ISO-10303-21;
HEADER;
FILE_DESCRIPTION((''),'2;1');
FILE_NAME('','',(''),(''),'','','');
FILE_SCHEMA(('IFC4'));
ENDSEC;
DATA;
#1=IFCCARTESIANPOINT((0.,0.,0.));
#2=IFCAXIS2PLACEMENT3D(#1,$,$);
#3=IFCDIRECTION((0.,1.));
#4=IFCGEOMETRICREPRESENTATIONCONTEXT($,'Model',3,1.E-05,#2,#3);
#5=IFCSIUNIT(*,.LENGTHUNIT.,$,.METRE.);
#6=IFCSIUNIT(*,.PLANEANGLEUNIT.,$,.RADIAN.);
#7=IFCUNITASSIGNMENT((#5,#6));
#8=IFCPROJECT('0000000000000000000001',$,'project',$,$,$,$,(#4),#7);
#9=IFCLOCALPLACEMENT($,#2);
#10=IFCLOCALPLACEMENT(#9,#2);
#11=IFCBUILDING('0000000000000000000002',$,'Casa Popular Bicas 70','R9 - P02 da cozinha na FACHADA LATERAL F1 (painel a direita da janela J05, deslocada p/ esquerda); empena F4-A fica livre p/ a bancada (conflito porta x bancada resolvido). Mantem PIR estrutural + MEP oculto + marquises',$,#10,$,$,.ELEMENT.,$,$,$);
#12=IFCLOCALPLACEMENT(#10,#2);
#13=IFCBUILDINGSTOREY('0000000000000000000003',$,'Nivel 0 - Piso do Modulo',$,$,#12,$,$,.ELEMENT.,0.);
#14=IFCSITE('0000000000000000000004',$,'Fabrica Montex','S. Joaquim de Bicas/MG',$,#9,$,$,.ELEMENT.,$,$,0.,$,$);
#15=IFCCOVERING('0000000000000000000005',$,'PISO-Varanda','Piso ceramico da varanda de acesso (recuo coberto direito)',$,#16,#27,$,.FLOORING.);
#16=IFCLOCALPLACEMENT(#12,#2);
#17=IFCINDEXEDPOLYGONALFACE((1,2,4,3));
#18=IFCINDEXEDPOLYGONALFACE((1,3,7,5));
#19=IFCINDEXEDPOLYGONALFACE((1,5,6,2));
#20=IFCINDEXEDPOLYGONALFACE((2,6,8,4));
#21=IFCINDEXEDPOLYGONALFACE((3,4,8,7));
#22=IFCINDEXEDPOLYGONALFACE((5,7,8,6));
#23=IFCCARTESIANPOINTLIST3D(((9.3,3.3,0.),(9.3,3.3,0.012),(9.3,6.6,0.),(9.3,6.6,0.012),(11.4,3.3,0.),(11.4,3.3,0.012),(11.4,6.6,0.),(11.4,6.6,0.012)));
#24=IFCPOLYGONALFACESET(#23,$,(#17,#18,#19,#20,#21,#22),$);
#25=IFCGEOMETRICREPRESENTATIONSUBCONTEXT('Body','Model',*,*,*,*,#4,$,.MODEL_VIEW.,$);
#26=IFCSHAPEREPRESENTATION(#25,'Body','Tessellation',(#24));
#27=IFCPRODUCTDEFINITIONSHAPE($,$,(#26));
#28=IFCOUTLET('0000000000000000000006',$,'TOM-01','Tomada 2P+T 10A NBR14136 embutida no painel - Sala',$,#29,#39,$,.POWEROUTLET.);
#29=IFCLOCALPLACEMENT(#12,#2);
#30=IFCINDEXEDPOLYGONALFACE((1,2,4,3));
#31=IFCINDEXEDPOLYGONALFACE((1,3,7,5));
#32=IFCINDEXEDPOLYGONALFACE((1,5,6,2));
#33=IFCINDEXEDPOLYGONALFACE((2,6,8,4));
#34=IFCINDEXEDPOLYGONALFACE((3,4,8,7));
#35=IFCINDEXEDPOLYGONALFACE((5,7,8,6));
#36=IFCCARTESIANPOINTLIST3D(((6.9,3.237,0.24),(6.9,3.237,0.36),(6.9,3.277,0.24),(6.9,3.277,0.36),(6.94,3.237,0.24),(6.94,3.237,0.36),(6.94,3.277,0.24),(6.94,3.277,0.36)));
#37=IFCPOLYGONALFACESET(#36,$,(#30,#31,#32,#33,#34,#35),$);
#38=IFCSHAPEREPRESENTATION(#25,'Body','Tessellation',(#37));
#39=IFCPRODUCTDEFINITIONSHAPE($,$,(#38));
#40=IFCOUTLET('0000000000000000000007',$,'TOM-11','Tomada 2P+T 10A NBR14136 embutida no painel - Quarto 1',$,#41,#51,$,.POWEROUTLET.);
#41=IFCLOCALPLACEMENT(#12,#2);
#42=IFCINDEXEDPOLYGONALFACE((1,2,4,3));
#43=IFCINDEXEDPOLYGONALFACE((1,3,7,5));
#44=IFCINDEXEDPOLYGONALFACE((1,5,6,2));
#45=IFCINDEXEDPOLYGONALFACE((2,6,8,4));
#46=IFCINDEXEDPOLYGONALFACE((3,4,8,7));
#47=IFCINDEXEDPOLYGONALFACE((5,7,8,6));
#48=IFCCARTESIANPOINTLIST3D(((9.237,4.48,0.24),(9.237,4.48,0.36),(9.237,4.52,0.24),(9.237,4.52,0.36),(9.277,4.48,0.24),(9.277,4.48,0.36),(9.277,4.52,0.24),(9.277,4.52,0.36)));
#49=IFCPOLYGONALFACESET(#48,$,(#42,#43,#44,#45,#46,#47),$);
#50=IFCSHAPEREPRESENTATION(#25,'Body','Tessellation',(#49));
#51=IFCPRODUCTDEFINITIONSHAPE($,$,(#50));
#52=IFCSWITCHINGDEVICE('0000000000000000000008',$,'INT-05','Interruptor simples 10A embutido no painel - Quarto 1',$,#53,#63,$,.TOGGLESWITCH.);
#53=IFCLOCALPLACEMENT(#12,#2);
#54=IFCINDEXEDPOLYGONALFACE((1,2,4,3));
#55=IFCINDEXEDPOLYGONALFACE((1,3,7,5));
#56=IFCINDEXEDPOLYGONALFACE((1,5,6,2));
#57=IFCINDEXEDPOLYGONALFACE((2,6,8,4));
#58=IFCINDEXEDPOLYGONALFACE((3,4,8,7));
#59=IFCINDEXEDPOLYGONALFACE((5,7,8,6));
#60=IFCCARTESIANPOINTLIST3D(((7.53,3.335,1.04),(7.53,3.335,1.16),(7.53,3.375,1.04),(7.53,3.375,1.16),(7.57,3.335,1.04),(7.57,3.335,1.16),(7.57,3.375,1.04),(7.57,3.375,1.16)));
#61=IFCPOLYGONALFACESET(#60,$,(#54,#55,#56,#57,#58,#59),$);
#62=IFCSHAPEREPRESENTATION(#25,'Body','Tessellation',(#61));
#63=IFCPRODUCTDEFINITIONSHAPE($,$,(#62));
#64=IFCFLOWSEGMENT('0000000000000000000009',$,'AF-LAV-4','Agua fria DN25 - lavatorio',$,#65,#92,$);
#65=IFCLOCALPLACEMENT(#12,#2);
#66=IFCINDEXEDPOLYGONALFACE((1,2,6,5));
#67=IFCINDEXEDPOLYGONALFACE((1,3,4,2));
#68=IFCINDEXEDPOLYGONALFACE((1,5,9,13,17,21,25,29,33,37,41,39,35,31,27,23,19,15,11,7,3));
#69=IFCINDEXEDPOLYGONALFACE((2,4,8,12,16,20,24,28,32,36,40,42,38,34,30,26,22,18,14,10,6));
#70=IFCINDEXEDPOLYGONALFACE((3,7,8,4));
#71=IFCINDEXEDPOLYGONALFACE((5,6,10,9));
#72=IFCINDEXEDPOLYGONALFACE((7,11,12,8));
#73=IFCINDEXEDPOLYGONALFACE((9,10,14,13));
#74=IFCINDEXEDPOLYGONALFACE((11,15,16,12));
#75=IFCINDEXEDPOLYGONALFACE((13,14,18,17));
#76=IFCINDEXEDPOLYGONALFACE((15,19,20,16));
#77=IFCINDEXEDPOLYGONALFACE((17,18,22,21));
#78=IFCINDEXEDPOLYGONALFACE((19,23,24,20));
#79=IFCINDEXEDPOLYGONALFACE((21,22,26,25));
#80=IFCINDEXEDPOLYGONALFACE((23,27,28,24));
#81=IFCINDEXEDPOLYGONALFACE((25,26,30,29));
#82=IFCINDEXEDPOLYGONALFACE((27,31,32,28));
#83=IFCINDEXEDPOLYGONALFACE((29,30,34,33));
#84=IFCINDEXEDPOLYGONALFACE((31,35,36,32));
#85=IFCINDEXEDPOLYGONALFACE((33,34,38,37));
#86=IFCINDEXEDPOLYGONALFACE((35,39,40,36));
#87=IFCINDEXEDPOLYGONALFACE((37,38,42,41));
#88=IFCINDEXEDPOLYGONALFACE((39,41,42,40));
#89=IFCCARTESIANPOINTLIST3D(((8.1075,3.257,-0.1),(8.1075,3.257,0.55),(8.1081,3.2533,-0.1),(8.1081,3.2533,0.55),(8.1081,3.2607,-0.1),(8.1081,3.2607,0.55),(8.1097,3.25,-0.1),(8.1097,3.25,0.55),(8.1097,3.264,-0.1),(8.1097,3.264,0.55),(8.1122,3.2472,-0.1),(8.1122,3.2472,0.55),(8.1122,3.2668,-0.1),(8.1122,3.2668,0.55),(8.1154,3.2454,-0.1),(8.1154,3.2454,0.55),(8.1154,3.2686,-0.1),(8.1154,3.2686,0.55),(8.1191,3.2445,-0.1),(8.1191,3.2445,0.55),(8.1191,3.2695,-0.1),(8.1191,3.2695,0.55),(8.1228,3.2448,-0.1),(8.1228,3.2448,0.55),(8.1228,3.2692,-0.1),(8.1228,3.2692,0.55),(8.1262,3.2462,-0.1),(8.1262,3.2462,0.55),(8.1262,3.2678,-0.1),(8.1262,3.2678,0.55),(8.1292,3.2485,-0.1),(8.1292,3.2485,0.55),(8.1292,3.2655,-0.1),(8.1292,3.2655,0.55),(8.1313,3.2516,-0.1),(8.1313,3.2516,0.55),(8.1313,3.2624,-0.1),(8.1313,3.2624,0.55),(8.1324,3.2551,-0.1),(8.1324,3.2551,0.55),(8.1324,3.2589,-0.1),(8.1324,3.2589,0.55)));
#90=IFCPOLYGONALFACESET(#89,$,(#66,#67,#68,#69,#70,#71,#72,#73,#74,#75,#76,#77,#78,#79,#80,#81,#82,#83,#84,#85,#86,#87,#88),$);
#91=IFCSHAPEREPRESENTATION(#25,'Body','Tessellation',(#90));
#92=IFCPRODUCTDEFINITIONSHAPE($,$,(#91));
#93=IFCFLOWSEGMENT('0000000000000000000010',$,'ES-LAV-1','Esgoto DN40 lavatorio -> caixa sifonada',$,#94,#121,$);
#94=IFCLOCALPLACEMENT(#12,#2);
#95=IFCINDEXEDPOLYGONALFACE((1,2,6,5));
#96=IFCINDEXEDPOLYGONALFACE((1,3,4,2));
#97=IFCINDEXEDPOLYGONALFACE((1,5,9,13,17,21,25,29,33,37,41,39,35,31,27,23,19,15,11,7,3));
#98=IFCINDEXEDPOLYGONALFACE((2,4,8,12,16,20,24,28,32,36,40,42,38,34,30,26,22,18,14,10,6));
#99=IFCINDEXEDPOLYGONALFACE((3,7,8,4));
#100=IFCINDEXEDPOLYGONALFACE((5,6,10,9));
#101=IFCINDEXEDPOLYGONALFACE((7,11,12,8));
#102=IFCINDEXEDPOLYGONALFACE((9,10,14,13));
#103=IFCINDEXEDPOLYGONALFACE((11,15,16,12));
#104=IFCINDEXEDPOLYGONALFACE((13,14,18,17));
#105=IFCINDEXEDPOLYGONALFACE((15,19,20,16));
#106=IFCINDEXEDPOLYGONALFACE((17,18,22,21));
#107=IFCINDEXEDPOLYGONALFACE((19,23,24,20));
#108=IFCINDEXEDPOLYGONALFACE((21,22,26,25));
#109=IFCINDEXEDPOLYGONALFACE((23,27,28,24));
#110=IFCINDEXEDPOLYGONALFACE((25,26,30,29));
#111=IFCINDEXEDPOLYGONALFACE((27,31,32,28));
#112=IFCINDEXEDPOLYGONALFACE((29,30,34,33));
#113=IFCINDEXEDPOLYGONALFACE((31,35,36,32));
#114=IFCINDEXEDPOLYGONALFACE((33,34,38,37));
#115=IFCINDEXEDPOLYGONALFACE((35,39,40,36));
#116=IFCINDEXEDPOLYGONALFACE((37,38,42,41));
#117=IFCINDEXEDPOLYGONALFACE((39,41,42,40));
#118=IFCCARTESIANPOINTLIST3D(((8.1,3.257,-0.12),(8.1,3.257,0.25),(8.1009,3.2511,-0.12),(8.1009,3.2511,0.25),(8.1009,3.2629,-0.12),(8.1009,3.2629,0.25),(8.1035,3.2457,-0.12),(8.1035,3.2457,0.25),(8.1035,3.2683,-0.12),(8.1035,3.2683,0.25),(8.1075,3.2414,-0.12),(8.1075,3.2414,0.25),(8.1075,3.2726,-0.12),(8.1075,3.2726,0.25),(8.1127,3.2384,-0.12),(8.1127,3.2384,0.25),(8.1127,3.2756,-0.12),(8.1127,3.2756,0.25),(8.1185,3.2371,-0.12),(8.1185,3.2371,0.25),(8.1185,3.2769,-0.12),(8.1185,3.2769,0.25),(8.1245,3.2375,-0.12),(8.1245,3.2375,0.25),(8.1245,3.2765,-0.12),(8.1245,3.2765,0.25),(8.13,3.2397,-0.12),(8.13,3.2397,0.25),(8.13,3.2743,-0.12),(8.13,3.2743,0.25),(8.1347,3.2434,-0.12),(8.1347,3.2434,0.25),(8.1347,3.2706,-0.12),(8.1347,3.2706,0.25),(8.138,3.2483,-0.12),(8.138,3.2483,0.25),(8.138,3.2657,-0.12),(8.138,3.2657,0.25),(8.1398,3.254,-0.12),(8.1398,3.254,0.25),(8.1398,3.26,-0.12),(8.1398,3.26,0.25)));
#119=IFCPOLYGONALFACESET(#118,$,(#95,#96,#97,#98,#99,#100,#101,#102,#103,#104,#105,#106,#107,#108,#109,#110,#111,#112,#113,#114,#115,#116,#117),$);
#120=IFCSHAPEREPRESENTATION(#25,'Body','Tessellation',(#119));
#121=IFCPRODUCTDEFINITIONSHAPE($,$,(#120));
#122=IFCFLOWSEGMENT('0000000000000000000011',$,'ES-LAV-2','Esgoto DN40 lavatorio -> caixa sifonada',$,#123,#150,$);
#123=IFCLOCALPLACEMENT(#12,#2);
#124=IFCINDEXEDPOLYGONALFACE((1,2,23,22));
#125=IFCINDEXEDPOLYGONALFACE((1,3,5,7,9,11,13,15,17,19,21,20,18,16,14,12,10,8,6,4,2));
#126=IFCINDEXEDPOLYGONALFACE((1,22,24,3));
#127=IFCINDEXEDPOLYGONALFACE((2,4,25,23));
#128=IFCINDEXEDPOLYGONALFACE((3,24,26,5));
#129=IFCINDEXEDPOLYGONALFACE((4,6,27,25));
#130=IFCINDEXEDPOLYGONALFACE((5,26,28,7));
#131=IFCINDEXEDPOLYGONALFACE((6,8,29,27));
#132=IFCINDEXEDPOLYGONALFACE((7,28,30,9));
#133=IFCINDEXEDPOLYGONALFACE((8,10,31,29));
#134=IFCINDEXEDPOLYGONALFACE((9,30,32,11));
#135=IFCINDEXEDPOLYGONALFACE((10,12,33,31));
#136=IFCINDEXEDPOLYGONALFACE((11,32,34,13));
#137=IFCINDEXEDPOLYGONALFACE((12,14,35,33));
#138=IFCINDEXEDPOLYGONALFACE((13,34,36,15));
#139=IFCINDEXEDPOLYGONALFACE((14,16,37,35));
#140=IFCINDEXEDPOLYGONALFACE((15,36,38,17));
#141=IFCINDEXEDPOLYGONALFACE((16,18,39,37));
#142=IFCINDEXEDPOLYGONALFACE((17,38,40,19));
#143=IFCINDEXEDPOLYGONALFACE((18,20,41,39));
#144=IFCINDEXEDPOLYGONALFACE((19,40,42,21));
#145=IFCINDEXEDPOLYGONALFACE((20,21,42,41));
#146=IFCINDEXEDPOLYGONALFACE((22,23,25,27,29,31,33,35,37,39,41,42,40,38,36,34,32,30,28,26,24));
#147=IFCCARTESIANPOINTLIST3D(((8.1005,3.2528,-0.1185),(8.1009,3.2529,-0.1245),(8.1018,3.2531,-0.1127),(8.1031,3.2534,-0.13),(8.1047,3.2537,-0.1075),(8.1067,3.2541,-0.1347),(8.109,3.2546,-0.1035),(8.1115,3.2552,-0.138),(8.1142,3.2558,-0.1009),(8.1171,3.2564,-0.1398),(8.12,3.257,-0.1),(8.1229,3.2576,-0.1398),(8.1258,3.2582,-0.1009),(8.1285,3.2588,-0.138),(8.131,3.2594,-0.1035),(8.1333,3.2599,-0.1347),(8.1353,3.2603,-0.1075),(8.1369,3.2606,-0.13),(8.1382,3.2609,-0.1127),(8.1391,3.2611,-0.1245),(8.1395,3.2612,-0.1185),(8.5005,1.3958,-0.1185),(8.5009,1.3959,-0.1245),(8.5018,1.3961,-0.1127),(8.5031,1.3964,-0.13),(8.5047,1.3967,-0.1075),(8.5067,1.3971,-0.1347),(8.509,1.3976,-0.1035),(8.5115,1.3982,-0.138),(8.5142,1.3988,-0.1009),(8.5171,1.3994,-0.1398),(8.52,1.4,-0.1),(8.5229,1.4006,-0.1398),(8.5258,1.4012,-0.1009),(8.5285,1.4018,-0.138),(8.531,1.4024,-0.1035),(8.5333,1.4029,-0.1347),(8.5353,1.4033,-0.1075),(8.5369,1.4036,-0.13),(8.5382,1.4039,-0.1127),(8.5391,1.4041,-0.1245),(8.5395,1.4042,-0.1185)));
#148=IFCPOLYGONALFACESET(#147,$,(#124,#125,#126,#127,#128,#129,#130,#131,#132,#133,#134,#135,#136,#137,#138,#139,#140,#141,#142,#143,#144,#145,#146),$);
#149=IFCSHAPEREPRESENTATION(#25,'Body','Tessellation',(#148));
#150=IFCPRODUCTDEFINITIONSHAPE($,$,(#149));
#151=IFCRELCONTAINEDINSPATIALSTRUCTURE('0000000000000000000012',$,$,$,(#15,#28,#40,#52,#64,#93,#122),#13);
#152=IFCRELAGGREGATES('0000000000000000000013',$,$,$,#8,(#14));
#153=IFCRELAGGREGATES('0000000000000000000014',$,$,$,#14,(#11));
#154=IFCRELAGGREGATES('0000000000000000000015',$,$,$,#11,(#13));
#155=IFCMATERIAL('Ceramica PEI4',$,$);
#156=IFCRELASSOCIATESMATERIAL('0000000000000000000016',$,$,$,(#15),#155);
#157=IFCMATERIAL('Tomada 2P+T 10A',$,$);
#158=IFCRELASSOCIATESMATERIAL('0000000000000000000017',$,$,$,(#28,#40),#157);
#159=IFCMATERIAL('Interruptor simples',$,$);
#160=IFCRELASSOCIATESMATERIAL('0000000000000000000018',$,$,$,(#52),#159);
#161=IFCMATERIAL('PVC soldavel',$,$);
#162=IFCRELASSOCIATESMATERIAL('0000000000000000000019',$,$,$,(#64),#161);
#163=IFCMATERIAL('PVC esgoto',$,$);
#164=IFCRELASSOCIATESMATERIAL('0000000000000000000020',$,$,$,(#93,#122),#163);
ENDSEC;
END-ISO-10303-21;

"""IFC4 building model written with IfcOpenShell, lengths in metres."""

from ifc_helpers import new_model, si_unit, direction, frame, frame_2d, origin, origin_2d, place, context, subcontext, project, spatial, rectangle, circle, extrude, material, element, save


model = new_model("IFC4")

# Units and contexts
model_context = context("Model", 3, precision=1e-05, world=origin(), true_north=direction((0.0, 1.0)))
body_context = subcontext(model_context, "Body", "Model", "MODEL_VIEW")
ifc_project = project(units=[si_unit("LENGTHUNIT", "METRE"), si_unit("PLANEANGLEUNIT", "RADIAN")], contexts=[model_context])

# Site, building, storey
site_placement = place(None, origin())
site = spatial("IfcSite", under=ifc_project, at=site_placement, Name="Fabrica Montex", Description="S. Joaquim de Bicas/MG", CompositionType="ELEMENT", RefElevation=0.0)
building_placement = place(site_placement, origin())
building = spatial("IfcBuilding", under=site, at=building_placement, Name="Casa Popular Bicas 70", Description="R9 - P02 da cozinha na FACHADA LATERAL F1 (painel a direita da janela J05, deslocada p/ esquerda); empena F4-A fica livre p/ a bancada (conflito porta x bancada resolvido). Mantem PIR estrutural + MEP oculto + marquises", CompositionType="ELEMENT")
storey_placement = place(building_placement, origin())
storey = spatial("IfcBuildingStorey", under=building, at=storey_placement, Name="Nivel 0 - Piso do Modulo", CompositionType="ELEMENT", Elevation=0.0)

# Covering
ifc_material_1 = material(Name="Ceramica PEI4")
covering_1_placement = place(storey_placement, frame((9.3, 3.3, 0.0)))
element("IfcCovering", 1, at=covering_1_placement, inside=storey, material=ifc_material_1, Name="PISO-Varanda", Description="Piso ceramico da varanda de acesso (recuo coberto direito)", PredefinedType="FLOORING", context=body_context, shape_type="SweptSolid", body=[
    extrude(rectangle(XDim=2.1, YDim=3.3, at=frame_2d((1.05, 1.65))), origin(), (0.0, 0.0, 1.0), 0.012),
])

# Outlets
ifc_material_2 = material(Name="Tomada 2P+T 10A")
outlet_1_placement = place(None, frame((6.94, 3.277, 0.24), z_axis=(0.0, 0.0, 1.0), x_axis=(-1.0, 0.0, 0.0)))
element("IfcOutlet", 2, at=outlet_1_placement, inside=storey, material=ifc_material_2, Name="TOM-01", Description="Tomada 2P+T 10A NBR14136 embutida no painel - Sala", PredefinedType="POWEROUTLET", context=body_context, shape_type="SweptSolid", body=[
    extrude(rectangle(XDim=0.04, YDim=0.04, at=frame_2d((0.02, 0.02))), origin(), (0.0, 0.0, 1.0), 0.12),
])
outlet_2_placement = place(storey_placement, frame((9.237, 4.48, 0.24)))
element("IfcOutlet", 3, at=outlet_2_placement, inside=storey, material=ifc_material_2, Name="TOM-11", Description="Tomada 2P+T 10A NBR14136 embutida no painel - Quarto 1", PredefinedType="POWEROUTLET", context=body_context, shape_type="SweptSolid", body=[
    extrude(rectangle(XDim=0.04, YDim=0.04, at=frame_2d((0.02, 0.02))), origin(), (0.0, 0.0, 1.0), 0.12),
])

# Switching device
ifc_material_3 = material(Name="Interruptor simples")
switching_device_placement = place(storey_placement, frame((7.53, 3.335, 1.04)))
element("IfcSwitchingDevice", 4, at=switching_device_placement, inside=storey, material=ifc_material_3, Name="INT-05", Description="Interruptor simples 10A embutido no painel - Quarto 1", PredefinedType="TOGGLESWITCH", context=body_context, shape_type="SweptSolid", body=[
    extrude(rectangle(XDim=0.04, YDim=0.04, at=frame_2d((0.02, 0.02))), origin(), (0.0, 0.0, 1.0), 0.12),
])

# Flow segments
ifc_material_4 = material(Name="PVC soldavel")
flow_segment_1_placement = place(None, frame((8.12, 3.257, -0.1), z_axis=(0.0, 0.0, 1.0), x_axis=(-1.0, 0.0, 0.0)))
element("IfcFlowSegment", 5, at=flow_segment_1_placement, inside=storey, material=ifc_material_4, Name="AF-LAV-4", Description="Agua fria DN25 - lavatorio", context=body_context, shape_type="SweptSolid", body=[
    extrude(circle(Radius=0.0125, at=origin_2d()), origin(), (0.0, 0.0, 1.0), 0.65),
])
ifc_material_5 = material(Name="PVC esgoto")
flow_segment_2_placement = place(None, frame((8.12, 3.257, 0.25), z_axis=(0.0, 0.0, -1.0), x_axis=(-1.0, 0.0, 0.0)))
element("IfcFlowSegment", 6, at=flow_segment_2_placement, inside=storey, material=ifc_material_5, Name="ES-LAV-1", Description="Esgoto DN40 lavatorio -> caixa sifonada", context=body_context, shape_type="SweptSolid", body=[
    extrude(circle(Radius=0.02, at=origin_2d()), origin(), (0.0, 0.0, 1.0), 0.37),
])
flow_segment_3_placement = place(None, frame((8.12, 3.257, -0.12), z_axis=(0.210572, -0.977578, 0.0), x_axis=(0.0, 0.0, 1.0)))
element("IfcFlowSegment", 7, at=flow_segment_3_placement, inside=storey, material=ifc_material_5, Name="ES-LAV-2", Description="Esgoto DN40 lavatorio -> caixa sifonada", context=body_context, shape_type="SweptSolid", body=[
    extrude(circle(Radius=0.02, at=origin_2d()), origin(), (0.0, 0.0, 1.0), 1.8996),
])

save(model, "model.ifc")
